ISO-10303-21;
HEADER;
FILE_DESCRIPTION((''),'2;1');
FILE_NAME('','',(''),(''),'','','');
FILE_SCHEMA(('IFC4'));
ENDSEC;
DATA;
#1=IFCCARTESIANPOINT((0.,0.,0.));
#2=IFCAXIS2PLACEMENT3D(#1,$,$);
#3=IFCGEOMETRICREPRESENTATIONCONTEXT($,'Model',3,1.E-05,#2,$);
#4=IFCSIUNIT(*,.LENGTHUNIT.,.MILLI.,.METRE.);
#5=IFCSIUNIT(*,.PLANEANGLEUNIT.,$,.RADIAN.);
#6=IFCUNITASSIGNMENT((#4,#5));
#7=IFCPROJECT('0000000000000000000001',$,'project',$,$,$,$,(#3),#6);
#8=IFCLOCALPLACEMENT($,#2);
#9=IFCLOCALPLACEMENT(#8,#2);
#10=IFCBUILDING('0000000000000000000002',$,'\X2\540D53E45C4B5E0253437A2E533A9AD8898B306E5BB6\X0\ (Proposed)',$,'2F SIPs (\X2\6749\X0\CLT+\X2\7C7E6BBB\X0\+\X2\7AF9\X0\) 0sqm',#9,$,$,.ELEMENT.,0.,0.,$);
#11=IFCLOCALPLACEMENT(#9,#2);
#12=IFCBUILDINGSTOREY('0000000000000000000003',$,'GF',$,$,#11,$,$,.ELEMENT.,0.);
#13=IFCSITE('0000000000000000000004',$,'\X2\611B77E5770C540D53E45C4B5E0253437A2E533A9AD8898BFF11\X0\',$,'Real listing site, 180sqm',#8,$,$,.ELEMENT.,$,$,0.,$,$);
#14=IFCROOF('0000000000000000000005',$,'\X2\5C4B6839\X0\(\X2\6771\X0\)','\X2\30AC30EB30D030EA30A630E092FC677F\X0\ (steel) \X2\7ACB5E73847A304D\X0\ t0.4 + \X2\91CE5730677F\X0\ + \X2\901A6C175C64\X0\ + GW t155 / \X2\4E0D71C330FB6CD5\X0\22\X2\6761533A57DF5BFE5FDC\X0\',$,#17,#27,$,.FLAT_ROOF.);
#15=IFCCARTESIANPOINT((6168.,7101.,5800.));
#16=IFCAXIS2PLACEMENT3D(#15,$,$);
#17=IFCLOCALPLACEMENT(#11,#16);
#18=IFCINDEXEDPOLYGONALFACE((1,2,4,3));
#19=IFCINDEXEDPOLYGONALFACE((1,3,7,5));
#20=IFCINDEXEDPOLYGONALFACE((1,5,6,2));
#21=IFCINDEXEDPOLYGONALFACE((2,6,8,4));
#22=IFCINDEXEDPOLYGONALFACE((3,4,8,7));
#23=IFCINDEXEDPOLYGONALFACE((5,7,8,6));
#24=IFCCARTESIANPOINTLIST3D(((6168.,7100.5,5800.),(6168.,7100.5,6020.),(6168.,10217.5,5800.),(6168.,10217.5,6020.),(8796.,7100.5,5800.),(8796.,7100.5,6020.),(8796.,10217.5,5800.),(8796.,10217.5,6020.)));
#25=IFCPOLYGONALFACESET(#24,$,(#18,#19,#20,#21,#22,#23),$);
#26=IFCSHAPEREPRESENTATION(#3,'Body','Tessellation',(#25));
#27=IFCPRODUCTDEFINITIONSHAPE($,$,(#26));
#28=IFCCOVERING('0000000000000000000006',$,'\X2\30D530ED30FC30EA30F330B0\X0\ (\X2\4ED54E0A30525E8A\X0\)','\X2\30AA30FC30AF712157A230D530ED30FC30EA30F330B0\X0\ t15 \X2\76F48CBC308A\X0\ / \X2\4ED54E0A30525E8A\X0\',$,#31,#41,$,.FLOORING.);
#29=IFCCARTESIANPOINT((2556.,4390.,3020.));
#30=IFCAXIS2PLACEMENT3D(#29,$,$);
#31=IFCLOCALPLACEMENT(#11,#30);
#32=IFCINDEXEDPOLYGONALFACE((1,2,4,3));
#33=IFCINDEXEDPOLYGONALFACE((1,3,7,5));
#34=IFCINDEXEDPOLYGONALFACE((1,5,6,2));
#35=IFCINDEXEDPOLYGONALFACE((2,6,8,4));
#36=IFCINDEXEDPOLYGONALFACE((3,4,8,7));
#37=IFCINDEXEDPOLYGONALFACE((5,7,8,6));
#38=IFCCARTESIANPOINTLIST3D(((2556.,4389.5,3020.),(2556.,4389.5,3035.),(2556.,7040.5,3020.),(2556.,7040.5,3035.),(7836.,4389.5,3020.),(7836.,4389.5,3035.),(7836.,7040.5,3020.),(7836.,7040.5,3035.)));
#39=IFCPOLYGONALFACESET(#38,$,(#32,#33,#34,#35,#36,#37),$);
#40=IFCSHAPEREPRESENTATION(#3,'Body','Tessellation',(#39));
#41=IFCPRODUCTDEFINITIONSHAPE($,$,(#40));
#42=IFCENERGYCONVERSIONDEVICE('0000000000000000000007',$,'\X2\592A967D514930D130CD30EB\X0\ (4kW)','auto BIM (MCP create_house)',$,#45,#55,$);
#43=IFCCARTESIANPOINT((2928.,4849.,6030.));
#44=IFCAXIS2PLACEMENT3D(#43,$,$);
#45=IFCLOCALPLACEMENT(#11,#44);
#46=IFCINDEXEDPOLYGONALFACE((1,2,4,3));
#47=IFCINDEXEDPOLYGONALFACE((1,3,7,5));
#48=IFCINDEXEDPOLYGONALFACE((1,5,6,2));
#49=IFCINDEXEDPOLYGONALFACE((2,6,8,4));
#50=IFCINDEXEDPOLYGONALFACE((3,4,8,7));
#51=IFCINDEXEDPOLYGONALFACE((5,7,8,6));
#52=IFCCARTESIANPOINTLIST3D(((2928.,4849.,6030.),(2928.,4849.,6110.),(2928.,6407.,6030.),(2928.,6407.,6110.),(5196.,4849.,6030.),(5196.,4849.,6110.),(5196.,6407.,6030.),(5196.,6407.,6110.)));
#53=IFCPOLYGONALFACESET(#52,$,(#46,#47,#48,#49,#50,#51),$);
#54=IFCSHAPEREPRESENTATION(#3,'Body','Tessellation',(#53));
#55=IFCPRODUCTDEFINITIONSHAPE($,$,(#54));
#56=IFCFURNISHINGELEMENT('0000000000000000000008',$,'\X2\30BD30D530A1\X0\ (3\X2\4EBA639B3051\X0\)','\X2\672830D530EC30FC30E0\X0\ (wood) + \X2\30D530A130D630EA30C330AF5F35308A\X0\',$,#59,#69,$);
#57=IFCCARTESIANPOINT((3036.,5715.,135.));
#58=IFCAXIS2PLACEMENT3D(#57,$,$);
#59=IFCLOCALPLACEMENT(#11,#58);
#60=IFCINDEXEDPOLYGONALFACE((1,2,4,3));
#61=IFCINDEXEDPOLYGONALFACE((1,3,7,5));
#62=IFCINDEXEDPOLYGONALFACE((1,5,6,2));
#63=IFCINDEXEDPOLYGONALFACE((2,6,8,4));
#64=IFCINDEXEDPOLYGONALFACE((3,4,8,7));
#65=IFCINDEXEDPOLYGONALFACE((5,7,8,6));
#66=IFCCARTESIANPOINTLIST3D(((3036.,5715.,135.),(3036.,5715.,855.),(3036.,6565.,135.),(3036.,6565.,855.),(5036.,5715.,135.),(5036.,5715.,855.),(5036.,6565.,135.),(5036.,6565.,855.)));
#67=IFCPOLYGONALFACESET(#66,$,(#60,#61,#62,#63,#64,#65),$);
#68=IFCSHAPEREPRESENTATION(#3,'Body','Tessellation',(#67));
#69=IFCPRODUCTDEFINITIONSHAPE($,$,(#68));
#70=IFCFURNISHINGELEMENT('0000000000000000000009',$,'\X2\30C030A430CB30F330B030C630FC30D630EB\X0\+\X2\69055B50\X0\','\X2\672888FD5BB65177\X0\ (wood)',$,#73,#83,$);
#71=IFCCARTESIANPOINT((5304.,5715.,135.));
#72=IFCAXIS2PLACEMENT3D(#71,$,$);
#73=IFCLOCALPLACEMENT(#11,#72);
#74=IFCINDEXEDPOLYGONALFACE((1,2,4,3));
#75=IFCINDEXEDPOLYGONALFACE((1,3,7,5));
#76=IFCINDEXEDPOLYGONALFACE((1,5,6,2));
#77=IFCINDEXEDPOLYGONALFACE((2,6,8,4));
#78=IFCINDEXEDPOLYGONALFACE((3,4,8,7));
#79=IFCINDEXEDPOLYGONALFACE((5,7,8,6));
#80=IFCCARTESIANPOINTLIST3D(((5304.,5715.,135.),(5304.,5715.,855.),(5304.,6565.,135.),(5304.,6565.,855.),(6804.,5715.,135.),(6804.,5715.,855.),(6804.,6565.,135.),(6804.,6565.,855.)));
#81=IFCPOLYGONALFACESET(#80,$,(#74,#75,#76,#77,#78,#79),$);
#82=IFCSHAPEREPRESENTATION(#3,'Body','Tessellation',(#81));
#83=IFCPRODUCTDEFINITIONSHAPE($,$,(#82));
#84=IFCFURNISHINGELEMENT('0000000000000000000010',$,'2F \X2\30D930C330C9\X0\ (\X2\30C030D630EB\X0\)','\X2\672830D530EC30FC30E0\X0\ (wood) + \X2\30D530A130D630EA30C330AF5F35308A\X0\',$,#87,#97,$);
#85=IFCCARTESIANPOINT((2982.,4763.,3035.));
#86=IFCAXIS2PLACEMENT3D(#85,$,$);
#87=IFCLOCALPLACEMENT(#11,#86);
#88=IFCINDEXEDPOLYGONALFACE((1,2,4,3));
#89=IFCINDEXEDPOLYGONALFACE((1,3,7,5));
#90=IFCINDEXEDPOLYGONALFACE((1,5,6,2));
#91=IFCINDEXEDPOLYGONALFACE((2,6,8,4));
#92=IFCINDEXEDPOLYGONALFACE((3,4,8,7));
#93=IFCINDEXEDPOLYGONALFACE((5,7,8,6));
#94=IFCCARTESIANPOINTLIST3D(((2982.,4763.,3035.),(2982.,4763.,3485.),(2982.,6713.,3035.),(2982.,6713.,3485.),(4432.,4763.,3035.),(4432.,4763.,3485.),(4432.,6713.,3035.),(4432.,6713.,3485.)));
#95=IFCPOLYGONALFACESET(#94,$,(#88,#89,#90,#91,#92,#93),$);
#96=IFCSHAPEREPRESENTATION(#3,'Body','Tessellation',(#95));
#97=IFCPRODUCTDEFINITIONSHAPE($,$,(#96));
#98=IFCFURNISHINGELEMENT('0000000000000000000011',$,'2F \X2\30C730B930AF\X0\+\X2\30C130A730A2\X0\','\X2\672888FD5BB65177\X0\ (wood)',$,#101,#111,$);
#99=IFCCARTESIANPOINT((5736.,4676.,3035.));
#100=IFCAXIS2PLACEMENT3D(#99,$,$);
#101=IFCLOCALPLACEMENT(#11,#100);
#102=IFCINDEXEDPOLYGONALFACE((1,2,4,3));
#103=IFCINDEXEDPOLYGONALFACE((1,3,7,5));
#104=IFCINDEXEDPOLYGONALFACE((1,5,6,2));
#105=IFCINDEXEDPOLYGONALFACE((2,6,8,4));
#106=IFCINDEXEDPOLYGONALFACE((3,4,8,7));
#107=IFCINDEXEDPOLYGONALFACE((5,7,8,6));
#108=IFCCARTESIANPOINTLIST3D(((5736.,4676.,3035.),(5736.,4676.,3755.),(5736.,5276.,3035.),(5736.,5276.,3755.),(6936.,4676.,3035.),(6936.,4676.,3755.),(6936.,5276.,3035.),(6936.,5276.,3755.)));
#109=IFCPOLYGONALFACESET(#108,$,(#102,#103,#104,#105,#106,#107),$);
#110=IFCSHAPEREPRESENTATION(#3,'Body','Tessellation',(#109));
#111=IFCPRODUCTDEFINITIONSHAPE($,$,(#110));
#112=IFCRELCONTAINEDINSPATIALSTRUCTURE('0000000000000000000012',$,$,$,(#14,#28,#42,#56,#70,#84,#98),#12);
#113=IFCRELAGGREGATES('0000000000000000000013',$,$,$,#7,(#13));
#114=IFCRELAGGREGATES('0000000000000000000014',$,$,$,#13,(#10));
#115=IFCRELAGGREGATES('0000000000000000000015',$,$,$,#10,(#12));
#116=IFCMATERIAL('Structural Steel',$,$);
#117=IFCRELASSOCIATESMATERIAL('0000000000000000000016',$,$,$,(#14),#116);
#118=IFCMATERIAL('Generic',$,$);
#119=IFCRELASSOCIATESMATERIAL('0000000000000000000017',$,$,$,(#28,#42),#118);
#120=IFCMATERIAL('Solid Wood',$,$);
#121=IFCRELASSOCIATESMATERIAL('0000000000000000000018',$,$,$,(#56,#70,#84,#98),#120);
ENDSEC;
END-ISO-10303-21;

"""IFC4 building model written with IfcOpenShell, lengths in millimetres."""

from ifc_helpers import new_model, si_unit, frame, frame_2d, origin, place, context, project, spatial, rectangle, extrude, material, element, save


model = new_model("IFC4")

# Units and contexts
model_context = context("Model", 3, precision=1e-05, world=origin())
ifc_project = project(units=[si_unit("LENGTHUNIT", "METRE", prefix="MILLI"), si_unit("PLANEANGLEUNIT", "RADIAN")], contexts=[model_context])

# Site, building, storey
site_placement = place(None, origin())
site = spatial("IfcSite", under=ifc_project, at=site_placement, Name="愛知県名古屋市千種区高見１", ObjectType="Real listing site, 180sqm", CompositionType="ELEMENT", RefElevation=0.0)
building_placement = place(site_placement, origin())
building = spatial("IfcBuilding", under=site, at=building_placement, Name="名古屋市千種区高見の家 (Proposed)", ObjectType="2F SIPs (杉CLT+籾殻+竹) 0sqm", CompositionType="ELEMENT", ElevationOfRefHeight=0.0, ElevationOfTerrain=0.0)
storey_placement = place(building_placement, origin())
storey = spatial("IfcBuildingStorey", under=building, at=storey_placement, Name="GF", CompositionType="ELEMENT", Elevation=0.0)

# Shared definitions
ifc_material_1 = material(Name="Solid Wood")

# Roof
ifc_material_2 = material(Name="Structural Steel")
roof_1_placement = place(storey_placement, frame((6168.0, 7101.0, 5800.0)))
element("IfcRoof", 1, at=roof_1_placement, inside=storey, material=ifc_material_2, Name="屋根(東)", Description="ガルバリウム鋼板 (steel) 立平葺き t0.4 + 野地板 + 通気層 + GW t155 / 不燃・法22条区域対応", PredefinedType="FLAT_ROOF", context=model_context, shape_type="SweptSolid", body=[
    extrude(rectangle(XDim=2628.0, YDim=3117.0, at=frame_2d((1314.0, 1558.0))), frame((6168.0, 7101.0, 5800.0)), (0.0, 0.0, 1.0), 220.0),
])

# Covering
ifc_material_3 = material(Name="Generic")
covering_placement = place(storey_placement, frame((2556.0, 4390.0, 3020.0)))
element("IfcCovering", 2, at=covering_placement, inside=storey, material=ifc_material_3, Name="フローリング (仕上げ床)", Description="オーク無垢フローリング t15 直貼り / 仕上げ床", PredefinedType="FLOORING", context=model_context, shape_type="SweptSolid", body=[
    extrude(rectangle(XDim=5280.0, YDim=2651.0, at=frame_2d((2640.0, 1325.0))), frame((2556.0, 4390.0, 3020.0)), (0.0, 0.0, 1.0), 15.0),
])

# Energy conversion device
energy_conversion_device_placement = place(storey_placement, frame((2928.0, 4849.0, 6030.0)))
element("IfcEnergyConversionDevice", 3, at=energy_conversion_device_placement, inside=storey, material=ifc_material_3, Name="太陽光パネル (4kW)", Description="auto BIM (MCP create_house)", context=model_context, shape_type="SweptSolid", body=[
    extrude(rectangle(XDim=2268.0, YDim=1558.0, at=frame_2d((1134.0, 779.0))), frame((2928.0, 4849.0, 6030.0)), (0.0, 0.0, 1.0), 80.0),
])

# Furnishing elements
furnishing_1_placement = place(storey_placement, frame((3036.0, 5715.0, 135.0)))
element("IfcFurnishingElement", 4, at=furnishing_1_placement, inside=storey, material=ifc_material_1, Name="ソファ (3人掛け)", Description="木フレーム (wood) + ファブリック張り", context=model_context, shape_type="SweptSolid", body=[
    extrude(rectangle(XDim=2000.0, YDim=850.0, at=frame_2d((1000.0, 425.0))), frame((3036.0, 5715.0, 135.0)), (0.0, 0.0, 1.0), 720.0),
])
furnishing_2_placement = place(storey_placement, frame((5304.0, 5715.0, 135.0)))
element("IfcFurnishingElement", 5, at=furnishing_2_placement, inside=storey, material=ifc_material_1, Name="ダイニングテーブル+椅子", Description="木製家具 (wood)", context=model_context, shape_type="SweptSolid", body=[
    extrude(rectangle(XDim=1500.0, YDim=850.0, at=frame_2d((750.0, 425.0))), frame((5304.0, 5715.0, 135.0)), (0.0, 0.0, 1.0), 720.0),
])
furnishing_3_placement = place(storey_placement, frame((2982.0, 4763.0, 3035.0)))
element("IfcFurnishingElement", 6, at=furnishing_3_placement, inside=storey, material=ifc_material_1, Name="2F ベッド (ダブル)", Description="木フレーム (wood) + ファブリック張り", context=model_context, shape_type="SweptSolid", body=[
    extrude(rectangle(XDim=1450.0, YDim=1950.0, at=frame_2d((725.0, 975.0))), frame((2982.0, 4763.0, 3035.0)), (0.0, 0.0, 1.0), 450.0),
])
furnishing_4_placement = place(storey_placement, frame((5736.0, 4676.0, 3035.0)))
element("IfcFurnishingElement", 7, at=furnishing_4_placement, inside=storey, material=ifc_material_1, Name="2F デスク+チェア", Description="木製家具 (wood)", context=model_context, shape_type="SweptSolid", body=[
    extrude(rectangle(XDim=1200.0, YDim=600.0, at=frame_2d((600.0, 300.0))), frame((5736.0, 4676.0, 3035.0)), (0.0, 0.0, 1.0), 720.0),
])

save(model, "model.ifc")
